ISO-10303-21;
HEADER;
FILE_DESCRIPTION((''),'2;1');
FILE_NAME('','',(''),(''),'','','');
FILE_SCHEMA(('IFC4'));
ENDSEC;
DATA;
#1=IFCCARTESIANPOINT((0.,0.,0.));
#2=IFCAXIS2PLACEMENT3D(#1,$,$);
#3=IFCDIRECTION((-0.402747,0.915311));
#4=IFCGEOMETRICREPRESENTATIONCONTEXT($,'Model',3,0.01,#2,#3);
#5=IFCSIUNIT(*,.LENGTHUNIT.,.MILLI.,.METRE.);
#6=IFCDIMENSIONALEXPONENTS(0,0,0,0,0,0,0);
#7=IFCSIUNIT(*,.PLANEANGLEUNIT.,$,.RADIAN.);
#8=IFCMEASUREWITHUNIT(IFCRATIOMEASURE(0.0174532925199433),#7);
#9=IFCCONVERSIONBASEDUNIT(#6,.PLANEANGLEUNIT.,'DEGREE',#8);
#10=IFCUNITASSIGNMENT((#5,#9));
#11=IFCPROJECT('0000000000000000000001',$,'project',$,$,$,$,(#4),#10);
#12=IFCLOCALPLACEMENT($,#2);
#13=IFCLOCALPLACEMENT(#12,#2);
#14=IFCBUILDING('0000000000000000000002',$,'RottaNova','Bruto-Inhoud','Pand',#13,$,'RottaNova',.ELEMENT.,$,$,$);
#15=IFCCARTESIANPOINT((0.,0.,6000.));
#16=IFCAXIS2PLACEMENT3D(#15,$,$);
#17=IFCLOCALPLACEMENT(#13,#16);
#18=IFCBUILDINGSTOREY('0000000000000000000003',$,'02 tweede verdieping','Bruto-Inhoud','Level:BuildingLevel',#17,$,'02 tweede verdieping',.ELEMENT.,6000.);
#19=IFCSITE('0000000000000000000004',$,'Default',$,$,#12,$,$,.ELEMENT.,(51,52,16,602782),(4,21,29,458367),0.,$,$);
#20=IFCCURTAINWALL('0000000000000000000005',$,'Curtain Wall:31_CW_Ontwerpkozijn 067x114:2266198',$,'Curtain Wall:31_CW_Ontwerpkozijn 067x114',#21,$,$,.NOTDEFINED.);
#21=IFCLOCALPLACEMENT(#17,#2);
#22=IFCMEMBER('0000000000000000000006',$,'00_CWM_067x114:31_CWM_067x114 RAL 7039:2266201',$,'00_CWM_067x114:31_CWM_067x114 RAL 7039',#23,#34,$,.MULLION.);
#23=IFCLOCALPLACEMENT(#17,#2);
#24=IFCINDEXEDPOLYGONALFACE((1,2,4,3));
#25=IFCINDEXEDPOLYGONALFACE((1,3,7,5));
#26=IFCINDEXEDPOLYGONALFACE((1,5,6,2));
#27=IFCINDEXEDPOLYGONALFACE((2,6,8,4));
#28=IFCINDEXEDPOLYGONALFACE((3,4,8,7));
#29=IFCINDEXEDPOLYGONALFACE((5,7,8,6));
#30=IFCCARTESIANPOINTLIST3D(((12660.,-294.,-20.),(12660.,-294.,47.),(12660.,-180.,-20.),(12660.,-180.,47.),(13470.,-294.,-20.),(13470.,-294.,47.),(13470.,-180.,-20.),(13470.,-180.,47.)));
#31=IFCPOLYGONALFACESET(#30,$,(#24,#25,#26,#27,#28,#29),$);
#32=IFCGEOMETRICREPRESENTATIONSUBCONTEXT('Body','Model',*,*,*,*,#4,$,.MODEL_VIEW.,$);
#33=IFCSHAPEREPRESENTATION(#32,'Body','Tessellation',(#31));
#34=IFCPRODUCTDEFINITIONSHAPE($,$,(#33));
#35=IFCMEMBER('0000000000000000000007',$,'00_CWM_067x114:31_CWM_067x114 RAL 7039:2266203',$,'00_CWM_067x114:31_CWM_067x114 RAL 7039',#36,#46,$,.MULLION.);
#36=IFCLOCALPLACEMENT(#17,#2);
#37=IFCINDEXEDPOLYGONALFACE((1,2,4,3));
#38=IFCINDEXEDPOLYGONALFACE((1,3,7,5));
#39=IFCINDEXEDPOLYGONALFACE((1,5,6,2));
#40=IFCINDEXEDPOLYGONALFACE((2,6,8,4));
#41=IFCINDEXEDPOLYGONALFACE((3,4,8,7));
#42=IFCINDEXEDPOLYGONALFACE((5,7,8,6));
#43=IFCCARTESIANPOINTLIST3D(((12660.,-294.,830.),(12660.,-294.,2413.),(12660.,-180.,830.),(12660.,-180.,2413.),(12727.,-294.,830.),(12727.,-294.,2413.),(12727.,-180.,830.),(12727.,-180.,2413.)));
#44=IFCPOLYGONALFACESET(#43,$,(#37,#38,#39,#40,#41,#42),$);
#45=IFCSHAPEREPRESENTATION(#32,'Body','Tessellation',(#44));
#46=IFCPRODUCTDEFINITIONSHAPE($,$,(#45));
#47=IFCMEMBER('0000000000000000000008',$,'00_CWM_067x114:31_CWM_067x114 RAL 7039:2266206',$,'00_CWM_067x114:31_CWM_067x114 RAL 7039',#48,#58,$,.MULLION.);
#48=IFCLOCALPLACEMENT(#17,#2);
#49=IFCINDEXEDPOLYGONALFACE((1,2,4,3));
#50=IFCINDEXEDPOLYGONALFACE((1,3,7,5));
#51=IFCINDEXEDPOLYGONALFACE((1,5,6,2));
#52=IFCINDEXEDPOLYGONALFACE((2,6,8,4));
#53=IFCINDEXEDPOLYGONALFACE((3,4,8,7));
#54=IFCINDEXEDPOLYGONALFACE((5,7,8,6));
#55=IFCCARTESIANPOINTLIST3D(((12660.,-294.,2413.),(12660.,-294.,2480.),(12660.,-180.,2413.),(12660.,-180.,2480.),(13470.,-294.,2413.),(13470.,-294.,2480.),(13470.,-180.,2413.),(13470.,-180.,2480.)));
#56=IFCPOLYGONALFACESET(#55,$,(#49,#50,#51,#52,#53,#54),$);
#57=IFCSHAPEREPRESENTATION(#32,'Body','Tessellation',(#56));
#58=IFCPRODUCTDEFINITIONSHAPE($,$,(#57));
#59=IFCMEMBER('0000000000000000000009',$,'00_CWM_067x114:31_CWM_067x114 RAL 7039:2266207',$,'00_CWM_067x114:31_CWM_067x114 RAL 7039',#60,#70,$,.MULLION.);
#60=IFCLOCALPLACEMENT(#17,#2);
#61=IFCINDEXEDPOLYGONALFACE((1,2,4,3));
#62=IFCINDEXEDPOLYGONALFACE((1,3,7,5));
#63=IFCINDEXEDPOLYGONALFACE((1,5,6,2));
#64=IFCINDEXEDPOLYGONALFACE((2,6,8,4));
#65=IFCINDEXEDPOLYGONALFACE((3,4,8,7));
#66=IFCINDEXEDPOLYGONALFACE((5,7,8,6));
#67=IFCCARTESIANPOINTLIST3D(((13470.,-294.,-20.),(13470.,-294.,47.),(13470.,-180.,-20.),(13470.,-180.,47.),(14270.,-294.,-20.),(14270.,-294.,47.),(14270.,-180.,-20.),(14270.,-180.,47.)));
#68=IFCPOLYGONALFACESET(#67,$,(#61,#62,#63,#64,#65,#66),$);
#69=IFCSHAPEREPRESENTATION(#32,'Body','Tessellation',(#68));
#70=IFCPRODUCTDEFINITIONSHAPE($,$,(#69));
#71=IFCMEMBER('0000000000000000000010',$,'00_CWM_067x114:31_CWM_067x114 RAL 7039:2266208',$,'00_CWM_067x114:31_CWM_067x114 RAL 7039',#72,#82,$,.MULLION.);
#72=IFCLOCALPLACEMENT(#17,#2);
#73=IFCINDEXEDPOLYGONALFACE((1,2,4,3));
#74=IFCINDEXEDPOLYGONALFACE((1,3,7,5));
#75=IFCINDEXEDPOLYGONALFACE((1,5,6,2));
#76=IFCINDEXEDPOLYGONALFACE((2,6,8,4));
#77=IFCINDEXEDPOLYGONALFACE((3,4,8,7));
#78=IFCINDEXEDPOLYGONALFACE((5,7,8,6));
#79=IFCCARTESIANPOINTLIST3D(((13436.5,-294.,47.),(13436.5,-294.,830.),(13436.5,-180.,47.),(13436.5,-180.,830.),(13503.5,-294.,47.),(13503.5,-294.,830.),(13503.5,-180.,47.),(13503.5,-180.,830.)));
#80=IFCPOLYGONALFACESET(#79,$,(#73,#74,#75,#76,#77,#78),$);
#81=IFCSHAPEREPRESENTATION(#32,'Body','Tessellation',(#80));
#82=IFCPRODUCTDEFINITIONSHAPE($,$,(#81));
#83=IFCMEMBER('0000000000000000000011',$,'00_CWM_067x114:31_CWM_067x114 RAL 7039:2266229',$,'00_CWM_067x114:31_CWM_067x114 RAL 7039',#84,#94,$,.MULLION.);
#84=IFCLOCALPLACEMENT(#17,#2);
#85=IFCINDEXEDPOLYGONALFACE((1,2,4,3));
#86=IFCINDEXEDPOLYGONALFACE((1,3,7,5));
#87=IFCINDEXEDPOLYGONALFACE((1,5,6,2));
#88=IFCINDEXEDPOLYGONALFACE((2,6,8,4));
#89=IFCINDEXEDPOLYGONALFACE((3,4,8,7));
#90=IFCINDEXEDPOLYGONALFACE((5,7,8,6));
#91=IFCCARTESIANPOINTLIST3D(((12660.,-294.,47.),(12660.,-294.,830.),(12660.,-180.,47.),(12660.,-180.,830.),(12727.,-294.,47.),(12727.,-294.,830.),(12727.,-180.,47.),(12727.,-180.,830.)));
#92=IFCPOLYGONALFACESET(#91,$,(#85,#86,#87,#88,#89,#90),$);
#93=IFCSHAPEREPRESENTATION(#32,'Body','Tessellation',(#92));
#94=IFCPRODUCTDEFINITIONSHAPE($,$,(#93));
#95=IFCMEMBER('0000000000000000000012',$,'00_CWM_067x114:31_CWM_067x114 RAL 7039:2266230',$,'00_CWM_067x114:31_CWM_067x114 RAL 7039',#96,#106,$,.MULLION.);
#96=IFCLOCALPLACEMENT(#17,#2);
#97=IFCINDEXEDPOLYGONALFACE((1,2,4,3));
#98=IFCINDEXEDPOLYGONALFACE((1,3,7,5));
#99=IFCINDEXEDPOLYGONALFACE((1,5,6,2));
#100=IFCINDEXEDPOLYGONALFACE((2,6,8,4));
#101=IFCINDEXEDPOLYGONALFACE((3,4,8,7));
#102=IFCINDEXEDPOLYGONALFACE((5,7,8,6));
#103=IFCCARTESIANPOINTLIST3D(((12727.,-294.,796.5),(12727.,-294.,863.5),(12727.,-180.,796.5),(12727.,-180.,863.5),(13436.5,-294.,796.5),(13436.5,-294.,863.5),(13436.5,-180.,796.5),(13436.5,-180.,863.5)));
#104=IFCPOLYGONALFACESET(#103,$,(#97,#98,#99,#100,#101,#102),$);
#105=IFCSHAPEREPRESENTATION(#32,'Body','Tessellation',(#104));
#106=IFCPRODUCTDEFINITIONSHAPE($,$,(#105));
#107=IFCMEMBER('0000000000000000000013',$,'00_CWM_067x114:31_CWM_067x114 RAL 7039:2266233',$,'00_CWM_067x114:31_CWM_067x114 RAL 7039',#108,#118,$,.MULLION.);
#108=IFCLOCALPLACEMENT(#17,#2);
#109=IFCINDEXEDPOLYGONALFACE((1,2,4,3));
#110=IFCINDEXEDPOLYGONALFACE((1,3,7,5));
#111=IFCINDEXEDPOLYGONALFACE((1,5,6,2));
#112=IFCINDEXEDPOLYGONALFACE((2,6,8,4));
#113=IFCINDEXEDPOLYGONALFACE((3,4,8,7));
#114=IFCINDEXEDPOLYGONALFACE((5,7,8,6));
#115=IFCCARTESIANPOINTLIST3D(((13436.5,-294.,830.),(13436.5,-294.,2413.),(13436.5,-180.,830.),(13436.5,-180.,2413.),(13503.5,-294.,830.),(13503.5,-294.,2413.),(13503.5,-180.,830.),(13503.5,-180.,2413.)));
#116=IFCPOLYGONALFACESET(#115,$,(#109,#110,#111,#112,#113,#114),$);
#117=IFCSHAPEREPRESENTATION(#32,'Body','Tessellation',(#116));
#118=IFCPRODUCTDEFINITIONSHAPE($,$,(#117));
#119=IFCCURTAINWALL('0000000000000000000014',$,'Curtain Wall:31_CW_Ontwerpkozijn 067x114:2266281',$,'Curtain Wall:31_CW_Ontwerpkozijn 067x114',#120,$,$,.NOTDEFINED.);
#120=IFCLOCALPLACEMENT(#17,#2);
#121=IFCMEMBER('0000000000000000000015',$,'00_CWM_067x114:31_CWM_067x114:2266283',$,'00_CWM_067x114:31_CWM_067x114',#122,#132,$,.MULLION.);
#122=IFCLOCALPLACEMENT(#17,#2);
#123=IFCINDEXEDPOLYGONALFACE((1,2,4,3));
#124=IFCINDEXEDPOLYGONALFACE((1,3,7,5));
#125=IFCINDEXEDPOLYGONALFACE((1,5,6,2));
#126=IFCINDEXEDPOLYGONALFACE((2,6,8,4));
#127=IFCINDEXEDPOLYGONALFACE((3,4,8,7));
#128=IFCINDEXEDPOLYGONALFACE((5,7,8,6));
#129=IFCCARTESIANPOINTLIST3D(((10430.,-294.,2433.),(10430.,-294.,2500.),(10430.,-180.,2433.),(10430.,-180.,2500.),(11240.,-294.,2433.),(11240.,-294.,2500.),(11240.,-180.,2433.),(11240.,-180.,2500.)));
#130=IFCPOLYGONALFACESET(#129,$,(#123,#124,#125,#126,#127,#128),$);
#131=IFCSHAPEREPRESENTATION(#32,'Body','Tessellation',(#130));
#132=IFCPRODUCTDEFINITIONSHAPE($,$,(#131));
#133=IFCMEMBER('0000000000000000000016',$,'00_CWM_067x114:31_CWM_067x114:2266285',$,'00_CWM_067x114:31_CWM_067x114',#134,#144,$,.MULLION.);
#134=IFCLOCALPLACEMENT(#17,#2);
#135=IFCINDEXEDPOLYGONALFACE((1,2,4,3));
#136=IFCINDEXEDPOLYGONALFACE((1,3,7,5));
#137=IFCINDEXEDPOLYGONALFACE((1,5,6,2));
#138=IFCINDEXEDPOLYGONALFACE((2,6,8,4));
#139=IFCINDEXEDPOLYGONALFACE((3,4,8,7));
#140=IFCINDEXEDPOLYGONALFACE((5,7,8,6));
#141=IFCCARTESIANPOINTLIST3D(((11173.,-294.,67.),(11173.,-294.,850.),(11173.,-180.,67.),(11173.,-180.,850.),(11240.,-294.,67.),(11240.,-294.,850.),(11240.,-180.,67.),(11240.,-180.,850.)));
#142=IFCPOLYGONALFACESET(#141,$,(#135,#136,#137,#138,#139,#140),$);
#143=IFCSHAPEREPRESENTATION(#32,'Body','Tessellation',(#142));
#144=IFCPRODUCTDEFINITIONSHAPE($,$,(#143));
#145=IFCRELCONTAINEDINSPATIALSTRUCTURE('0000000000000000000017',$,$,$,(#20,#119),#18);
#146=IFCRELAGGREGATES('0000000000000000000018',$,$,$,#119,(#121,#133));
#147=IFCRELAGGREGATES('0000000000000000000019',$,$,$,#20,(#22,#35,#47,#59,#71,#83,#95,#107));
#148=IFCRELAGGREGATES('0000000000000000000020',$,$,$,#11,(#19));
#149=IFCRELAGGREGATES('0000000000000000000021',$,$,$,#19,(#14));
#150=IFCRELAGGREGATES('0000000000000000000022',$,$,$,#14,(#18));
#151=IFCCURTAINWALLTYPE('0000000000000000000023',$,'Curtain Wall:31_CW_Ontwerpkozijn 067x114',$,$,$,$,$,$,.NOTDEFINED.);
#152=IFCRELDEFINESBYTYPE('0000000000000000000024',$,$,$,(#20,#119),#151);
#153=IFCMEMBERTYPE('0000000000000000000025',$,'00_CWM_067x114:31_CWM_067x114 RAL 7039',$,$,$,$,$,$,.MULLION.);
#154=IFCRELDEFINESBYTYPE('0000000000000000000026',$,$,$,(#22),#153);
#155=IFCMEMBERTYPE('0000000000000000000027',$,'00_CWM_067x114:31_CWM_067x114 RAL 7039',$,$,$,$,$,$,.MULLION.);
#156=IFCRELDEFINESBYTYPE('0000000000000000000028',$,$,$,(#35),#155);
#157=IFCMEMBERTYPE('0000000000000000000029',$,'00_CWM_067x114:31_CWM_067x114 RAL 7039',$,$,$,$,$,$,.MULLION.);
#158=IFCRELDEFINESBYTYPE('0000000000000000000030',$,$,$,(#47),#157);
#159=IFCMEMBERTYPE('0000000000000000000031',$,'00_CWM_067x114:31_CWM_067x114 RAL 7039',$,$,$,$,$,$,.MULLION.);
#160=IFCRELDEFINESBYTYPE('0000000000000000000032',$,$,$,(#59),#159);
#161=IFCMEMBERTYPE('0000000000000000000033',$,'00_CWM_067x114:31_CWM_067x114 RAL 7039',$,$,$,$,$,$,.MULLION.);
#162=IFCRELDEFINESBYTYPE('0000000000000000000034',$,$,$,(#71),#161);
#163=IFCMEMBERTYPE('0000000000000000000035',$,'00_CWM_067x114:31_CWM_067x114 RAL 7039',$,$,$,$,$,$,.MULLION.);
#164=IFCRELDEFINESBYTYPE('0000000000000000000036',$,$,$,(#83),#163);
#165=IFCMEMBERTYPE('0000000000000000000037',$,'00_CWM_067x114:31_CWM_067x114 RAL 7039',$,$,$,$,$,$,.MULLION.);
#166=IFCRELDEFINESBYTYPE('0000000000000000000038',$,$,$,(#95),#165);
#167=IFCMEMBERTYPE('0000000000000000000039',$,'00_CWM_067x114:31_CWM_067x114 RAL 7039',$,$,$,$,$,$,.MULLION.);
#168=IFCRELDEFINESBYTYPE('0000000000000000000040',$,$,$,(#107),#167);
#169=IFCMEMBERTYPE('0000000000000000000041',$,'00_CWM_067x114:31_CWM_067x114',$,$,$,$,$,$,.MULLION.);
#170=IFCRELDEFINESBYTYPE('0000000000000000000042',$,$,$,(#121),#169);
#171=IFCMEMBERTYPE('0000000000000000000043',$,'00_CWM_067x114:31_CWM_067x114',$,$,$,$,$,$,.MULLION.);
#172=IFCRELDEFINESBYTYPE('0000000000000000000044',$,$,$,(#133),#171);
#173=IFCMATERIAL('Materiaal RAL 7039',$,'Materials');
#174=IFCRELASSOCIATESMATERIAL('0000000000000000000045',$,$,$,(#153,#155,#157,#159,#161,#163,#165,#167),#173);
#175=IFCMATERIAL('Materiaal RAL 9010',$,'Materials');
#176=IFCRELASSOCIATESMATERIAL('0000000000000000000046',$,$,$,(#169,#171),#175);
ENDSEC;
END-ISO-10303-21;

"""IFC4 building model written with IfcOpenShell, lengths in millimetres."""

from ifc_helpers import new_model, entity, si_unit, converted_unit, direction, frame, origin, origin_2d_with_axis, place, context, subcontext, project, spatial, rectangle, extrude, source, transform, mapped, material, material_profile, profile_set, type_object, type_shapes, element, aggregate, save


model = new_model("IFC4")

# Units and contexts
model_context = context("Model", 3, precision=0.01, world=origin(), true_north=direction((-0.402747, 0.915311)))
body_context = subcontext(model_context, "Body", "Model", "MODEL_VIEW")
ifc_project = project(units=[si_unit("LENGTHUNIT", "METRE", prefix="MILLI"), converted_unit("PLANEANGLEUNIT", "DEGREE", entity("IfcRatioMeasure", 0.0174532925199433), si_unit("PLANEANGLEUNIT", "RADIAN"), dimensions=[0, 0, 0, 0, 0, 0, 0])], contexts=[model_context])

# Site, building, storey
site_placement = place(None, origin())
site = spatial("IfcSite", under=ifc_project, at=site_placement, Name="Default", CompositionType="ELEMENT", RefLatitude=(51, 52, 16, 602782), RefLongitude=(4, 21, 29, 458367), RefElevation=0.0)
building_placement = place(site_placement, origin())
building = spatial("IfcBuilding", under=site, at=building_placement, Name="RottaNova", Description="Bruto-Inhoud", ObjectType="Pand", LongName="RottaNova", CompositionType="ELEMENT")
storey_placement = place(building_placement, frame((0.0, 0.0, 6000.0)))
storey = spatial("IfcBuildingStorey", under=building, at=storey_placement, Name="02 tweede verdieping", Description="Bruto-Inhoud", ObjectType="Level:BuildingLevel", LongName="02 tweede verdieping", CompositionType="ELEMENT", Elevation=6000.0)

# Curtain walls, members
curtain_wall_type = type_object("IfcCurtainWallType", Name="Curtain Wall:31_CW_Ontwerpkozijn 067x114", PredefinedType="NOTDEFINED")
curtain_wall_1_placement = place(storey_placement, frame((0.0, 0.0, -6000.0)))
curtain_wall_1 = element("IfcCurtainWall", 1, at=curtain_wall_1_placement, inside=storey, type_object=curtain_wall_type, Name="Curtain Wall:31_CW_Ontwerpkozijn 067x114:2266198", ObjectType="Curtain Wall:31_CW_Ontwerpkozijn 067x114", PredefinedType="NOTDEFINED")
ifc_material_1 = material(Name="Materiaal RAL 7039", Category="Materials")
ifc_material_profile_1 = material_profile(ifc_material_1, rectangle(XDim=114.0, YDim=67.0, at=origin_2d_with_axis()), Name="31_CWM_067x114 RAL 7039")
ifc_profile_set_1 = profile_set([ifc_material_profile_1], Name="31_CWM_067x114 RAL 7039")
member_type_1 = type_object("IfcMemberType", Name="00_CWM_067x114:31_CWM_067x114 RAL 7039", PredefinedType="MULLION", material=ifc_profile_set_1)
shared_shape_1 = source(origin(), body_context, "Body", "SweptSolid", [
    extrude(rectangle(XDim=114.0, YDim=67.0, at=origin_2d_with_axis()), frame((-33.5, 57.0, -810.0), z_axis=(0.0, 0.0, 1.0), x_axis=(0.0, -1.0, 0.0)), (0.0, 0.0, 1.0), 810.0),
])
type_shapes(member_type_1, [shared_shape_1])
member_1_placement = place(curtain_wall_1_placement, frame((12660.0, -180.0, 5980.0), z_axis=(-1.0, 0.0, 0.0), x_axis=(0.0, 0.0, -1.0)))
member_1 = element("IfcMember", 2, at=member_1_placement, type_object=member_type_1, Name="00_CWM_067x114:31_CWM_067x114 RAL 7039:2266201", ObjectType="00_CWM_067x114:31_CWM_067x114 RAL 7039", PredefinedType="MULLION", context=body_context, shape_type="MappedRepresentation", body=[
    mapped(shared_shape_1, transform((0.0, 0.0, 0.0), scale=1.0)),
])
member_type_2 = type_object("IfcMemberType", Name="00_CWM_067x114:31_CWM_067x114 RAL 7039", PredefinedType="MULLION", material=ifc_profile_set_1)
shared_shape_2 = source(origin(), body_context, "Body", "SweptSolid", [
    extrude(rectangle(XDim=114.0, YDim=67.0, at=origin_2d_with_axis()), frame((-33.5, 57.0, -1583.0), z_axis=(0.0, 0.0, 1.0), x_axis=(0.0, -1.0, 0.0)), (0.0, 0.0, 1.0), 1583.0),
])
type_shapes(member_type_2, [shared_shape_2])
member_2_placement = place(curtain_wall_1_placement, frame((12660.0, -180.0, 8413.0), z_axis=(0.0, 0.0, 1.0), x_axis=(-1.0, 0.0, 0.0)))
member_2 = element("IfcMember", 3, at=member_2_placement, type_object=member_type_2, Name="00_CWM_067x114:31_CWM_067x114 RAL 7039:2266203", ObjectType="00_CWM_067x114:31_CWM_067x114 RAL 7039", PredefinedType="MULLION", context=body_context, shape_type="MappedRepresentation", body=[
    mapped(shared_shape_2, transform((0.0, 0.0, 0.0), scale=1.0)),
])
member_type_3 = type_object("IfcMemberType", Name="00_CWM_067x114:31_CWM_067x114 RAL 7039", PredefinedType="MULLION", material=ifc_profile_set_1)
shared_shape_3 = source(origin(), body_context, "Body", "SweptSolid", [
    extrude(rectangle(XDim=114.0, YDim=67.0, at=origin_2d_with_axis()), frame((-33.5, 57.0, -810.0), z_axis=(0.0, 0.0, 1.0), x_axis=(0.0, -1.0, 0.0)), (0.0, 0.0, 1.0), 810.0),
])
type_shapes(member_type_3, [shared_shape_3])
member_3_placement = place(curtain_wall_1_placement, frame((13470.0, -180.0, 8480.0), z_axis=(1.0, 0.0, 0.0), x_axis=(0.0, 0.0, 1.0)))
member_3 = element("IfcMember", 4, at=member_3_placement, type_object=member_type_3, Name="00_CWM_067x114:31_CWM_067x114 RAL 7039:2266206", ObjectType="00_CWM_067x114:31_CWM_067x114 RAL 7039", PredefinedType="MULLION", context=body_context, shape_type="MappedRepresentation", body=[
    mapped(shared_shape_3, transform((0.0, 0.0, 0.0), scale=1.0)),
])
member_type_4 = type_object("IfcMemberType", Name="00_CWM_067x114:31_CWM_067x114 RAL 7039", PredefinedType="MULLION", material=ifc_profile_set_1)
shared_shape_4 = source(origin(), body_context, "Body", "SweptSolid", [
    extrude(rectangle(XDim=114.0, YDim=67.0, at=origin_2d_with_axis()), frame((-33.5, 57.0, -800.0), z_axis=(0.0, 0.0, 1.0), x_axis=(0.0, -1.0, 0.0)), (0.0, 0.0, 1.0), 800.0),
])
type_shapes(member_type_4, [shared_shape_4])
member_4_placement = place(curtain_wall_1_placement, frame((13470.0, -180.0, 5980.0), z_axis=(-1.0, 0.0, 0.0), x_axis=(0.0, 0.0, -1.0)))
member_4 = element("IfcMember", 5, at=member_4_placement, type_object=member_type_4, Name="00_CWM_067x114:31_CWM_067x114 RAL 7039:2266207", ObjectType="00_CWM_067x114:31_CWM_067x114 RAL 7039", PredefinedType="MULLION", context=body_context, shape_type="MappedRepresentation", body=[
    mapped(shared_shape_4, transform((0.0, 0.0, 0.0), scale=1.0)),
])
member_type_5 = type_object("IfcMemberType", Name="00_CWM_067x114:31_CWM_067x114 RAL 7039", PredefinedType="MULLION", material=ifc_profile_set_1)
shared_shape_5 = source(origin(), body_context, "Body", "SweptSolid", [
    extrude(rectangle(XDim=114.0, YDim=67.0, at=origin_2d_with_axis()), frame((0.0, 57.0, -783.0), z_axis=(0.0, 0.0, 1.0), x_axis=(0.0, -1.0, 0.0)), (0.0, 0.0, 1.0), 783.0),
])
type_shapes(member_type_5, [shared_shape_5])
member_5_placement = place(curtain_wall_1_placement, frame((13470.0, -180.0, 6047.0), z_axis=(0.0, 0.0, -1.0), x_axis=(1.0, 0.0, 0.0)))
member_5 = element("IfcMember", 6, at=member_5_placement, type_object=member_type_5, Name="00_CWM_067x114:31_CWM_067x114 RAL 7039:2266208", ObjectType="00_CWM_067x114:31_CWM_067x114 RAL 7039", PredefinedType="MULLION", context=body_context, shape_type="MappedRepresentation", body=[
    mapped(shared_shape_5, transform((0.0, 0.0, 0.0), scale=1.0)),
])
member_type_6 = type_object("IfcMemberType", Name="00_CWM_067x114:31_CWM_067x114 RAL 7039", PredefinedType="MULLION", material=ifc_profile_set_1)
shared_shape_6 = source(origin(), body_context, "Body", "SweptSolid", [
    extrude(rectangle(XDim=114.0, YDim=67.0, at=origin_2d_with_axis()), frame((-33.5, 57.0, -783.0), z_axis=(0.0, 0.0, 1.0), x_axis=(0.0, -1.0, 0.0)), (0.0, 0.0, 1.0), 783.0),
])
type_shapes(member_type_6, [shared_shape_6])
member_6_placement = place(curtain_wall_1_placement, frame((12660.0, -180.0, 6830.0), z_axis=(0.0, 0.0, 1.0), x_axis=(-1.0, 0.0, 0.0)))
member_6 = element("IfcMember", 7, at=member_6_placement, type_object=member_type_6, Name="00_CWM_067x114:31_CWM_067x114 RAL 7039:2266229", ObjectType="00_CWM_067x114:31_CWM_067x114 RAL 7039", PredefinedType="MULLION", context=body_context, shape_type="MappedRepresentation", body=[
    mapped(shared_shape_6, transform((0.0, 0.0, 0.0), scale=1.0)),
])
member_type_7 = type_object("IfcMemberType", Name="00_CWM_067x114:31_CWM_067x114 RAL 7039", PredefinedType="MULLION", material=ifc_profile_set_1)
shared_shape_7 = source(origin(), body_context, "Body", "SweptSolid", [
    extrude(rectangle(XDim=114.0, YDim=67.0, at=origin_2d_with_axis()), frame((0.0, 57.0, -709.5), z_axis=(0.0, 0.0, 1.0), x_axis=(0.0, -1.0, 0.0)), (0.0, 0.0, 1.0), 709.5),
])
type_shapes(member_type_7, [shared_shape_7])
member_7_placement = place(curtain_wall_1_placement, frame((13436.5, -180.0, 6830.0), z_axis=(1.0, 0.0, 0.0), x_axis=(0.0, 0.0, 1.0)))
member_7 = element("IfcMember", 8, at=member_7_placement, type_object=member_type_7, Name="00_CWM_067x114:31_CWM_067x114 RAL 7039:2266230", ObjectType="00_CWM_067x114:31_CWM_067x114 RAL 7039", PredefinedType="MULLION", context=body_context, shape_type="MappedRepresentation", body=[
    mapped(shared_shape_7, transform((0.0, 0.0, 0.0), scale=1.0)),
])
member_type_8 = type_object("IfcMemberType", Name="00_CWM_067x114:31_CWM_067x114 RAL 7039", PredefinedType="MULLION", material=ifc_profile_set_1)
shared_shape_8 = source(origin(), body_context, "Body", "SweptSolid", [
    extrude(rectangle(XDim=114.0, YDim=67.0, at=origin_2d_with_axis()), frame((0.0, 57.0, -1583.0), z_axis=(0.0, 0.0, 1.0), x_axis=(0.0, -1.0, 0.0)), (0.0, 0.0, 1.0), 1583.0),
])
type_shapes(member_type_8, [shared_shape_8])
member_8_placement = place(curtain_wall_1_placement, frame((13470.0, -180.0, 6830.0), z_axis=(0.0, 0.0, -1.0), x_axis=(1.0, 0.0, 0.0)))
member_8 = element("IfcMember", 9, at=member_8_placement, type_object=member_type_8, Name="00_CWM_067x114:31_CWM_067x114 RAL 7039:2266233", ObjectType="00_CWM_067x114:31_CWM_067x114 RAL 7039", PredefinedType="MULLION", context=body_context, shape_type="MappedRepresentation", body=[
    mapped(shared_shape_8, transform((0.0, 0.0, 0.0), scale=1.0)),
])
curtain_wall_2_placement = place(storey_placement, frame((0.0, 0.0, -6000.0)))
curtain_wall_2 = element("IfcCurtainWall", 10, at=curtain_wall_2_placement, inside=storey, type_object=curtain_wall_type, Name="Curtain Wall:31_CW_Ontwerpkozijn 067x114:2266281", ObjectType="Curtain Wall:31_CW_Ontwerpkozijn 067x114", PredefinedType="NOTDEFINED")
ifc_material_2 = material(Name="Materiaal RAL 9010", Category="Materials")
ifc_material_profile_2 = material_profile(ifc_material_2, rectangle(XDim=114.0, YDim=67.0, at=origin_2d_with_axis()), Name="31_CWM_067x114")
ifc_profile_set_2 = profile_set([ifc_material_profile_2], Name="31_CWM_067x114")
member_type_9 = type_object("IfcMemberType", Name="00_CWM_067x114:31_CWM_067x114", PredefinedType="MULLION", material=ifc_profile_set_2)
shared_shape_9 = source(origin(), body_context, "Body", "SweptSolid", [
    extrude(rectangle(XDim=114.0, YDim=67.0, at=origin_2d_with_axis()), frame((-33.5, 57.0, -810.0), z_axis=(0.0, 0.0, 1.0), x_axis=(0.0, -1.0, 0.0)), (0.0, 0.0, 1.0), 810.0),
])
type_shapes(member_type_9, [shared_shape_9])
member_9_placement = place(curtain_wall_2_placement, frame((11240.0, -180.0, 8500.0), z_axis=(1.0, 0.0, 0.0), x_axis=(0.0, 0.0, 1.0)))
member_9 = element("IfcMember", 11, at=member_9_placement, type_object=member_type_9, Name="00_CWM_067x114:31_CWM_067x114:2266283", ObjectType="00_CWM_067x114:31_CWM_067x114", PredefinedType="MULLION", context=body_context, shape_type="MappedRepresentation", body=[
    mapped(shared_shape_9, transform((0.0, 0.0, 0.0), scale=1.0)),
])
member_type_10 = type_object("IfcMemberType", Name="00_CWM_067x114:31_CWM_067x114", PredefinedType="MULLION", material=ifc_profile_set_2)
shared_shape_10 = source(origin(), body_context, "Body", "SweptSolid", [
    extrude(rectangle(XDim=114.0, YDim=67.0, at=origin_2d_with_axis()), frame((-33.5, 57.0, -783.0), z_axis=(0.0, 0.0, 1.0), x_axis=(0.0, -1.0, 0.0)), (0.0, 0.0, 1.0), 783.0),
])
type_shapes(member_type_10, [shared_shape_10])
member_10_placement = place(curtain_wall_2_placement, frame((11240.0, -180.0, 6067.0), z_axis=(0.0, 0.0, -1.0), x_axis=(1.0, 0.0, 0.0)))
member_10 = element("IfcMember", 12, at=member_10_placement, type_object=member_type_10, Name="00_CWM_067x114:31_CWM_067x114:2266285", ObjectType="00_CWM_067x114:31_CWM_067x114", PredefinedType="MULLION", context=body_context, shape_type="MappedRepresentation", body=[
    mapped(shared_shape_10, transform((0.0, 0.0, 0.0), scale=1.0)),
])
aggregate(curtain_wall_2, [member_9, member_10])

aggregate(curtain_wall_1, [member_1, member_2, member_3, member_4, member_5, member_6, member_7, member_8])

save(model, "model.ifc")
